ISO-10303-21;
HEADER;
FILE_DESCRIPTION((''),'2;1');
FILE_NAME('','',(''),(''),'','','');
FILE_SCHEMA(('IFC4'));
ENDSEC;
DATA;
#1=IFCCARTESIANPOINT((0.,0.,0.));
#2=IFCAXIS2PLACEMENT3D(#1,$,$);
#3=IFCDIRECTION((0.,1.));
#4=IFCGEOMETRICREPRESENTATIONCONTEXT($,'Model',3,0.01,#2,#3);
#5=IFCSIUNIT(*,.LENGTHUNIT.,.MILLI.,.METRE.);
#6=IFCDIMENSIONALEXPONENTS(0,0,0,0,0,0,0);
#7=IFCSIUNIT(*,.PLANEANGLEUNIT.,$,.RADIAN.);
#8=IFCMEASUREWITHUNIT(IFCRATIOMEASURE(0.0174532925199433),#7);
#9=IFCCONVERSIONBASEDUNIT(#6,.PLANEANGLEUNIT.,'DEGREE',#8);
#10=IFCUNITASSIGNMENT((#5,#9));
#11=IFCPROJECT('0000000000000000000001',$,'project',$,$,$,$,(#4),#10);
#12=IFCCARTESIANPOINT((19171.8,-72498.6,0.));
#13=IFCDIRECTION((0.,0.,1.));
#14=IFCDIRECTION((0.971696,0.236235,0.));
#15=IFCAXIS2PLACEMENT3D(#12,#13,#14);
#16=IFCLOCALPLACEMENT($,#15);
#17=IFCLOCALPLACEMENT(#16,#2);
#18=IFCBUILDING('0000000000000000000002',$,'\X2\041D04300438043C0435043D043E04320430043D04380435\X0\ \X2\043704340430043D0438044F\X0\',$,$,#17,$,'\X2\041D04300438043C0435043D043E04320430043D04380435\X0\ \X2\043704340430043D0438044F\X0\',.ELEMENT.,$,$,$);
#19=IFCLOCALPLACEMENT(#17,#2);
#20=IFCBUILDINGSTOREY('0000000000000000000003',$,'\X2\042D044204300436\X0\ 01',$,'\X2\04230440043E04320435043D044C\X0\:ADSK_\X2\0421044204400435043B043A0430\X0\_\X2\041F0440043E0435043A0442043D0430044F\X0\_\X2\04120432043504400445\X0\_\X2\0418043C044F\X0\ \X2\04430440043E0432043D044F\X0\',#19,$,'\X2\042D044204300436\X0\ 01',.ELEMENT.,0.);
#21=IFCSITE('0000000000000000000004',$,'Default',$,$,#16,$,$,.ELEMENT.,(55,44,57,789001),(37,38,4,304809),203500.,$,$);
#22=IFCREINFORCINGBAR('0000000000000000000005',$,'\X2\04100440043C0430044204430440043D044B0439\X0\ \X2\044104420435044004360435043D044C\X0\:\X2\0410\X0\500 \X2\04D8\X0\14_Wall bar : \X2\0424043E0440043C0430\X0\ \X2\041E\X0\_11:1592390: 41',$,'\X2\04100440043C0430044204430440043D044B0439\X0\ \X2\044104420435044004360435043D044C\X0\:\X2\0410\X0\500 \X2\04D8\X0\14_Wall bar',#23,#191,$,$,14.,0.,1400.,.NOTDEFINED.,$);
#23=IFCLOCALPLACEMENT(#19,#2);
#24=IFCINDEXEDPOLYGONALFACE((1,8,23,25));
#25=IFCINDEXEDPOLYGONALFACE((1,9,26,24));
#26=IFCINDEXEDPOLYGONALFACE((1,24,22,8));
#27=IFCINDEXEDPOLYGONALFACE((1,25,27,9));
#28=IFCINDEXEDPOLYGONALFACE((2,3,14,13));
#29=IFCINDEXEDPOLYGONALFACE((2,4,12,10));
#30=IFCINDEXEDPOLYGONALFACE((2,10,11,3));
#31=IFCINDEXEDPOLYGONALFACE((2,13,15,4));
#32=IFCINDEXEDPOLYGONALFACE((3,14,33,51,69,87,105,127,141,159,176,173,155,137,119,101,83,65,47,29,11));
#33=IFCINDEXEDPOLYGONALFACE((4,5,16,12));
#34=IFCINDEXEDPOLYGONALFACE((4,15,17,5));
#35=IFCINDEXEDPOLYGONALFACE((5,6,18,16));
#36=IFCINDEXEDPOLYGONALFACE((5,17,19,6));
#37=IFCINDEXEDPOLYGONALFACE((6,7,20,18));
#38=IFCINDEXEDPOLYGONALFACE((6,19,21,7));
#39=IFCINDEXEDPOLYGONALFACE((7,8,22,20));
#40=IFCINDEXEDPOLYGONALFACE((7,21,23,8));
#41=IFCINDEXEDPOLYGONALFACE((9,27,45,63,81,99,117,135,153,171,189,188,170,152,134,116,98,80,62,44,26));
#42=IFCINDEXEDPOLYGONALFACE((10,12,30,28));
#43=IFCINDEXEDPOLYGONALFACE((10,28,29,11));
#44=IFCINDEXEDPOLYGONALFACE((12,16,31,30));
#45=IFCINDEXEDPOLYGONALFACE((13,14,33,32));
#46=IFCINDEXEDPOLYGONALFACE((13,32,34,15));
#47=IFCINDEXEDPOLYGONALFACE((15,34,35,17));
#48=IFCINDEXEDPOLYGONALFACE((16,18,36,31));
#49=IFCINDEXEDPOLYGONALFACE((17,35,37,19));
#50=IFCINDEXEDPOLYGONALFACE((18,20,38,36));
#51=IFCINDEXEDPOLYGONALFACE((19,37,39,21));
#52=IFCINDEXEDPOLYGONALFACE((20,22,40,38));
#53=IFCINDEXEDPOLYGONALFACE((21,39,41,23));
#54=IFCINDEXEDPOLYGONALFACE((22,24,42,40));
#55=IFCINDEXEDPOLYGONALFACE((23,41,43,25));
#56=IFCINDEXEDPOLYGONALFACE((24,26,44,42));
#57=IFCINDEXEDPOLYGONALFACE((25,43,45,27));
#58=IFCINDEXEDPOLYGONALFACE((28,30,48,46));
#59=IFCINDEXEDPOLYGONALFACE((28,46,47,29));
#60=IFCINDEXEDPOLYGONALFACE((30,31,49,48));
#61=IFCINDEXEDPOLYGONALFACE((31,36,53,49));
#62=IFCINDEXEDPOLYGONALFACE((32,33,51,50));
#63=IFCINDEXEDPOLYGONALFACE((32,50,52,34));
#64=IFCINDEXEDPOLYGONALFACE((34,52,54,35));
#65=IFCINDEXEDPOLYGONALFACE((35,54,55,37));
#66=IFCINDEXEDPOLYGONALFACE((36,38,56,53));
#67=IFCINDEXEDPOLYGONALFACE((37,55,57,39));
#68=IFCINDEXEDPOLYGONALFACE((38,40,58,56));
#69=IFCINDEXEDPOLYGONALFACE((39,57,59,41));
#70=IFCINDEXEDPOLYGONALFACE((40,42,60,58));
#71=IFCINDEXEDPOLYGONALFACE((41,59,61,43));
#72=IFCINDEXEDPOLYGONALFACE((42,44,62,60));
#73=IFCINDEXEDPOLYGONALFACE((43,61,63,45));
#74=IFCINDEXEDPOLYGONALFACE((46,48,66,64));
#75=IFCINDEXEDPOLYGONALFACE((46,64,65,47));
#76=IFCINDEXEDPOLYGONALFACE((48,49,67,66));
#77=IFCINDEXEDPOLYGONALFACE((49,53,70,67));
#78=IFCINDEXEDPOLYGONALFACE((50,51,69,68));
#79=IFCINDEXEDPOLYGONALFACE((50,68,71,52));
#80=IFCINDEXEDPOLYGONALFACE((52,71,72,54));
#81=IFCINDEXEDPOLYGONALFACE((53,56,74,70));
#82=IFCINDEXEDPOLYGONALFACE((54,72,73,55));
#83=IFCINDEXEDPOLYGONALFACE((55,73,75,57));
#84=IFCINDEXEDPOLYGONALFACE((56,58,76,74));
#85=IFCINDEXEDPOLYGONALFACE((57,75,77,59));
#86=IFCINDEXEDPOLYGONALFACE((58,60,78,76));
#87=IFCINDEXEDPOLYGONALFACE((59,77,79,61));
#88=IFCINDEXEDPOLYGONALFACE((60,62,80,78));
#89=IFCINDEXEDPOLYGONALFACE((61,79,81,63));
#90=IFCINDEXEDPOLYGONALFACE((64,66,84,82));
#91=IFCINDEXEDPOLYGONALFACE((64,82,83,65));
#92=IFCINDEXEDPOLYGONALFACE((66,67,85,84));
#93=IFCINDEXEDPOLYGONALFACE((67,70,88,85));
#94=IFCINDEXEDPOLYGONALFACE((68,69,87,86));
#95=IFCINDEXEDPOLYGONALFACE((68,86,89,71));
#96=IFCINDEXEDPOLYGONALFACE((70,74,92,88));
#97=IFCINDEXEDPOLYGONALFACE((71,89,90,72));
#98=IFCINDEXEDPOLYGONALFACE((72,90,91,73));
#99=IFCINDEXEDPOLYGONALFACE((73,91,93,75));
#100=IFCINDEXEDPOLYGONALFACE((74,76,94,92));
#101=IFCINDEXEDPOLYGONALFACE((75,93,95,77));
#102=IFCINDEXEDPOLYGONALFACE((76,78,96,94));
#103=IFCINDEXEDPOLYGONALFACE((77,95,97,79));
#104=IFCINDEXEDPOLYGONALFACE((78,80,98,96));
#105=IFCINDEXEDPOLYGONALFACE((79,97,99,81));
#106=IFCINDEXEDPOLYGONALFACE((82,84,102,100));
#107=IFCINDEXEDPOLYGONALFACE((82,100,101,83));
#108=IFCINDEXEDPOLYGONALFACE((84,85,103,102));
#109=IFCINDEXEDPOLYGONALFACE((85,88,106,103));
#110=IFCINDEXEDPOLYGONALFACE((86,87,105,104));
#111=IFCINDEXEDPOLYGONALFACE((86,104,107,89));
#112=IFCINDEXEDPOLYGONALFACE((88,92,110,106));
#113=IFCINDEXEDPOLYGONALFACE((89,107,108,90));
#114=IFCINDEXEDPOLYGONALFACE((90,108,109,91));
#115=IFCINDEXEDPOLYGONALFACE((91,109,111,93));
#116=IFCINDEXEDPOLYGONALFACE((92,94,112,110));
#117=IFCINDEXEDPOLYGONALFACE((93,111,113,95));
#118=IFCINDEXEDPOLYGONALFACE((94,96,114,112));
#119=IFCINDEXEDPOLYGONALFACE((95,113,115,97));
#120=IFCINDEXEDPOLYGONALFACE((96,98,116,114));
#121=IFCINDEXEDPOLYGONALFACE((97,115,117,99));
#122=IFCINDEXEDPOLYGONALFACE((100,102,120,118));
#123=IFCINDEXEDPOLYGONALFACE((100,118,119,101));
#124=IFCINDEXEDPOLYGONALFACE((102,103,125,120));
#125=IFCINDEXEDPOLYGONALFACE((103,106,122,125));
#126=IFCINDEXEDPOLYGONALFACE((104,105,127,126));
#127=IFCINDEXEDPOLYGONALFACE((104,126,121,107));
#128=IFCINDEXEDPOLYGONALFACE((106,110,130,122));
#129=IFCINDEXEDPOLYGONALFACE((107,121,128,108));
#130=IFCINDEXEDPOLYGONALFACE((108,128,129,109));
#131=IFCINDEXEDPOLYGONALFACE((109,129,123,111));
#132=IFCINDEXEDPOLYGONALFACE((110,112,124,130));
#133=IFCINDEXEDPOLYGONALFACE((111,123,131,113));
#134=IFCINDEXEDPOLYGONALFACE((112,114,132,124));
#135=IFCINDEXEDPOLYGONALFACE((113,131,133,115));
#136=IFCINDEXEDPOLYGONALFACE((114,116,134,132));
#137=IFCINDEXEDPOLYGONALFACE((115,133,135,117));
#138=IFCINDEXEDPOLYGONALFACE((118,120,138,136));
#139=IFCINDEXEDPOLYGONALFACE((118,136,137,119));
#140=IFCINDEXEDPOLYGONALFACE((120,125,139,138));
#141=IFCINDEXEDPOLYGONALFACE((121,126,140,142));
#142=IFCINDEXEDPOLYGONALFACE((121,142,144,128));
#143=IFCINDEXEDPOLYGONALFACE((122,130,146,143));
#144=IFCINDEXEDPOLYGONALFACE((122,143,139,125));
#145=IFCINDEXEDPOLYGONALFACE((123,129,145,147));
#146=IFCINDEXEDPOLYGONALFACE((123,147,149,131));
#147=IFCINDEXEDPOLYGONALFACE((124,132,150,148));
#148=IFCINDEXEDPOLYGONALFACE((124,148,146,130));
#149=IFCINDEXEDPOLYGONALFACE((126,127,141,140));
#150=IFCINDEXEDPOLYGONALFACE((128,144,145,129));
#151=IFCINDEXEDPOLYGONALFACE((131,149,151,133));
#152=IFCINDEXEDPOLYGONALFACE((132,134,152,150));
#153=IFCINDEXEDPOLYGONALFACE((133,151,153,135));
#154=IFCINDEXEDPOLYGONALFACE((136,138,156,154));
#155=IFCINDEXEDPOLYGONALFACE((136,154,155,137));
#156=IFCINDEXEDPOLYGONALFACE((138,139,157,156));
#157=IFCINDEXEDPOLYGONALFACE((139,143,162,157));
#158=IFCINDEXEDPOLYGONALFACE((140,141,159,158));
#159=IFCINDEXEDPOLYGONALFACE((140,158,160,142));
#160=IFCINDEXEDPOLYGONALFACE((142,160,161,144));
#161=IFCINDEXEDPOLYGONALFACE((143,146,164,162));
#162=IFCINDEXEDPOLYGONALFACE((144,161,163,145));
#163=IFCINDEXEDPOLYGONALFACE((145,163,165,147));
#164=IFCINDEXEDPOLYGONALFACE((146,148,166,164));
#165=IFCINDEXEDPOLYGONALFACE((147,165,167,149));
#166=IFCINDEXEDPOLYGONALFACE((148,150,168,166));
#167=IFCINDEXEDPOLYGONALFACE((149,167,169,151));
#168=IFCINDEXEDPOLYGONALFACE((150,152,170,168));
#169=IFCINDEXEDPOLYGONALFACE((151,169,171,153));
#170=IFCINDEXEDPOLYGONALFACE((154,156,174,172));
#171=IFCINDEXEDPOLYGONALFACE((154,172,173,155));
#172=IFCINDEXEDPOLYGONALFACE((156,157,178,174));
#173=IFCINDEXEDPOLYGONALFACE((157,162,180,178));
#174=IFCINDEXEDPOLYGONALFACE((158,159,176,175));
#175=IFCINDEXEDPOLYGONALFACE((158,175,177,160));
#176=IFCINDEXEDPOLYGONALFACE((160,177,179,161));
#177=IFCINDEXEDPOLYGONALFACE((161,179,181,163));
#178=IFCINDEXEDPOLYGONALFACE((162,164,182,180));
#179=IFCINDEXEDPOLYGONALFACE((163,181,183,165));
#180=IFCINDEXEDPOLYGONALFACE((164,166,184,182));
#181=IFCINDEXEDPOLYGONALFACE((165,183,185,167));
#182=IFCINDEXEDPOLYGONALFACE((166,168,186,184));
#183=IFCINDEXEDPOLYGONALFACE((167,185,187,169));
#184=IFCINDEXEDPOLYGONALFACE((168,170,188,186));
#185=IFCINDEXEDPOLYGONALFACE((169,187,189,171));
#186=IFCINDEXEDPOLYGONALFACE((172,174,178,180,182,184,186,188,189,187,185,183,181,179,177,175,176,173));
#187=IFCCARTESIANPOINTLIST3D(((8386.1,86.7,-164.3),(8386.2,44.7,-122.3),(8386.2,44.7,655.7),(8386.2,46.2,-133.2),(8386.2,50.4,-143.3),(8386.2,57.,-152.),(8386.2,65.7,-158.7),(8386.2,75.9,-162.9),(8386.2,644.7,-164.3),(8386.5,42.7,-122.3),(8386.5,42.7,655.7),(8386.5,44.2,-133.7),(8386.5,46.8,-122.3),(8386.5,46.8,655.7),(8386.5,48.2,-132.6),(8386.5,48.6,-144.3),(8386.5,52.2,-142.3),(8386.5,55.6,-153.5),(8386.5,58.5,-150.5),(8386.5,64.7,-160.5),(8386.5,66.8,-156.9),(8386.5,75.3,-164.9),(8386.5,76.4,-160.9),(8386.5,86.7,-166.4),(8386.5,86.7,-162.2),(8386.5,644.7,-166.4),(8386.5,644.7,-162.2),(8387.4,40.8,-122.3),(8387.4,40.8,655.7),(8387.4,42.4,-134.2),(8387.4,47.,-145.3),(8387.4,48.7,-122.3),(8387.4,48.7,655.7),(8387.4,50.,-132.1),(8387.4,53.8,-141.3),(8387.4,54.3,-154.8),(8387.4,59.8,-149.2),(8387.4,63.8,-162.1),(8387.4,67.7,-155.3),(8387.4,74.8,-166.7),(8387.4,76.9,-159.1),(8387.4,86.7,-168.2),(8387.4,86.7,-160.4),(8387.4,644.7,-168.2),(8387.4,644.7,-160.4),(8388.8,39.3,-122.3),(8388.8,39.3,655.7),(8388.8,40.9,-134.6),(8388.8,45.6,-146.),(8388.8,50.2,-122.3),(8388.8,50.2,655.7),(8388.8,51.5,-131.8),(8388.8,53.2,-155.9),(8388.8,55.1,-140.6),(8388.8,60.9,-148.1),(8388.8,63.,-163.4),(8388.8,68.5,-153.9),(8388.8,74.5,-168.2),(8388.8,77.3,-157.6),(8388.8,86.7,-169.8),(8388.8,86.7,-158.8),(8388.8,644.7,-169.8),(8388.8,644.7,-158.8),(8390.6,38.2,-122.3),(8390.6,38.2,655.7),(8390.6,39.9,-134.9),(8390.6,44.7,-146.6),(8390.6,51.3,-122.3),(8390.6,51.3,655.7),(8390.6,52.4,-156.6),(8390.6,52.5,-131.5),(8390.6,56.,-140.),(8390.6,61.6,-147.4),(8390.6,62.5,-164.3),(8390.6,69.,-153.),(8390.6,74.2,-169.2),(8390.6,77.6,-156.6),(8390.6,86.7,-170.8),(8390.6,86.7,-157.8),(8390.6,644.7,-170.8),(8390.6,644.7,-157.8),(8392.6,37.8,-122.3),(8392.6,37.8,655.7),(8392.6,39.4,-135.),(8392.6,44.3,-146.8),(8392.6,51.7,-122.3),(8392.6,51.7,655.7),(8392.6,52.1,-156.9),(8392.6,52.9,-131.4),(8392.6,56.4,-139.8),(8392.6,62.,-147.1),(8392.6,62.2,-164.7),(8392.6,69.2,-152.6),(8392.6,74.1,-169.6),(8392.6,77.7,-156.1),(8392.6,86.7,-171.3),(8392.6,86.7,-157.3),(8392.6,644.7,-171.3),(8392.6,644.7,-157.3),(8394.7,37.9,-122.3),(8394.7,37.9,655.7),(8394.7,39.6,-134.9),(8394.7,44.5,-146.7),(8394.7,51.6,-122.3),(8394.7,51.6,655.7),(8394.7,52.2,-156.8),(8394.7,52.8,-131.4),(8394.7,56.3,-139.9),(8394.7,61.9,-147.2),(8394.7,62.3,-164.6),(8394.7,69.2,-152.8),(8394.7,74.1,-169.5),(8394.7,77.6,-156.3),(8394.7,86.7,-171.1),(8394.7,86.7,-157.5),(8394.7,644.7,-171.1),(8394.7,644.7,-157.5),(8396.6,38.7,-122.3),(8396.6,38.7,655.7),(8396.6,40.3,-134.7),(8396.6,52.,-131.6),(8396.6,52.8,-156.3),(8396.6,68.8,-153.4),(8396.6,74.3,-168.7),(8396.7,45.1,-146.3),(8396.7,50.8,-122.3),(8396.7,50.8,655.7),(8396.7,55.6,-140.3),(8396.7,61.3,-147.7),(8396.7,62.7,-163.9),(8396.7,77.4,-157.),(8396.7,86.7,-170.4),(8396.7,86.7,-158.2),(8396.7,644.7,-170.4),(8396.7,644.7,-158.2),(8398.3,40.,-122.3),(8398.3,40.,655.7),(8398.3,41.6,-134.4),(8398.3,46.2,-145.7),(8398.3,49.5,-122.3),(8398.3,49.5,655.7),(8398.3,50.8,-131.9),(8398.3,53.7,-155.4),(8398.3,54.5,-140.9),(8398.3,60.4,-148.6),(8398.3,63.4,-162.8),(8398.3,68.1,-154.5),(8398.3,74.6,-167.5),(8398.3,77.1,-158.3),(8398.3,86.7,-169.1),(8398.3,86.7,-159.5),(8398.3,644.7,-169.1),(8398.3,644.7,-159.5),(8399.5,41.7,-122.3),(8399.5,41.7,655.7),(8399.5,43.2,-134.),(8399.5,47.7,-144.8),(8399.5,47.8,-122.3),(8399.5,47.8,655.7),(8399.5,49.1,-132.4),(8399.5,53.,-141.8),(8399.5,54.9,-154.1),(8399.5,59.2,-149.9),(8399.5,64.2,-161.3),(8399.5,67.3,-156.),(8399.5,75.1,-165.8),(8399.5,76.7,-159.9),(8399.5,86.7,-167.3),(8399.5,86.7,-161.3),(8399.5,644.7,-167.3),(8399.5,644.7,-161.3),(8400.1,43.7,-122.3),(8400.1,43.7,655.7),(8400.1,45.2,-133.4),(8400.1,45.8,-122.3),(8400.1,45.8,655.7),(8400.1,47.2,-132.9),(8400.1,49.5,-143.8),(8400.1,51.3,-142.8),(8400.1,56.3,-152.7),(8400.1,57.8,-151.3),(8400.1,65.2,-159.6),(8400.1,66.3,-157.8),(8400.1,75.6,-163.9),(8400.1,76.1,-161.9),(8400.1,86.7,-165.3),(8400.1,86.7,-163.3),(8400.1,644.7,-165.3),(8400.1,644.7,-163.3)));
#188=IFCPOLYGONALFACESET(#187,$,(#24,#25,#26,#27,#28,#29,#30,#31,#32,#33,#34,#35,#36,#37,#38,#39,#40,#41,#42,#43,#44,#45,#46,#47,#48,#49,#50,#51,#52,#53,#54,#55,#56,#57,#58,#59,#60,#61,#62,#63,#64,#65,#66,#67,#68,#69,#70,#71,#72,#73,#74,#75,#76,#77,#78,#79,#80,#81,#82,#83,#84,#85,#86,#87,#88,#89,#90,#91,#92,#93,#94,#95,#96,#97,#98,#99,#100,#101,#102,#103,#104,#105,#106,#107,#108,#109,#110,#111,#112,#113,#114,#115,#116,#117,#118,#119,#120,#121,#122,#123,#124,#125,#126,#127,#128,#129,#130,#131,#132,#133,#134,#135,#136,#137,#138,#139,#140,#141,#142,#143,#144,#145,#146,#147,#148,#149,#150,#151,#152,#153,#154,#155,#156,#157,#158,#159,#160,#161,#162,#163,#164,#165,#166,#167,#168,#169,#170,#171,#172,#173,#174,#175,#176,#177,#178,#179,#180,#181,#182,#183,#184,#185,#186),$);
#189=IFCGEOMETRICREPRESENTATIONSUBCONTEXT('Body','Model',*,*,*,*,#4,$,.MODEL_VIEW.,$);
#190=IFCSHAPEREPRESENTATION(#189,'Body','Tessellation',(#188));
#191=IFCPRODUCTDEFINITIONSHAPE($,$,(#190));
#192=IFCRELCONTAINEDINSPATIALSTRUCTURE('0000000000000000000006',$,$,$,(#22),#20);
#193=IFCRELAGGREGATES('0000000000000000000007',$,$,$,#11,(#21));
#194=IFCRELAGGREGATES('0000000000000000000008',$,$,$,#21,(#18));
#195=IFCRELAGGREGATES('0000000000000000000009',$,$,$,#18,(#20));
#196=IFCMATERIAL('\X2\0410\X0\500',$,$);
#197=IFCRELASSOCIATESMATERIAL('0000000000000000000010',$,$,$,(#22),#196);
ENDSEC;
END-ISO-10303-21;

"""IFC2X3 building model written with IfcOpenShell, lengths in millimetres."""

from ifc_helpers import new_model, entity, si_unit, converted_unit, direction, frame, origin, place, context, subcontext, project, spatial, material, element, save


model = new_model("IFC2X3")

# Units and contexts
model_context = context("Model", 3, precision=0.01, world=origin(), true_north=direction((0.0, 1.0)))
body_context = subcontext(model_context, "Body", "Model", "MODEL_VIEW")
ifc_project = project(units=[si_unit("LENGTHUNIT", "METRE", prefix="MILLI"), converted_unit("PLANEANGLEUNIT", "DEGREE", entity("IfcRatioMeasure", 0.0174532925199433), si_unit("PLANEANGLEUNIT", "RADIAN"), dimensions=[0, 0, 0, 0, 0, 0, 0])], contexts=[model_context])

# Site, building, storey
site_placement = place(None, frame((19171.8, -72498.6, 0.0), z_axis=(0.0, 0.0, 1.0), x_axis=(0.971696, 0.236235, 0.0)))
site = spatial("IfcSite", under=ifc_project, at=site_placement, Name="Default", CompositionType="ELEMENT", RefLatitude=(55, 44, 57, 789001), RefLongitude=(37, 38, 4, 304809), RefElevation=203500.0)
building_placement = place(site_placement, origin())
building = spatial("IfcBuilding", under=site, at=building_placement, Name="Наименование здания", LongName="Наименование здания", CompositionType="ELEMENT")
storey_placement = place(building_placement, origin())
storey = spatial("IfcBuildingStorey", under=building, at=storey_placement, Name="Этаж 01", ObjectType="Уровень:ADSK_Стрелка_Проектная_Вверх_Имя уровня", LongName="Этаж 01", CompositionType="ELEMENT", Elevation=0.0)

# Reinforcing bar
ifc_material = material(Name="А500")
placement = place(storey_placement, origin())
element("IfcReinforcingBar", 1, at=placement, inside=storey, material=ifc_material, Name="Арматурный стержень:А500 Ә14_Wall bar : Форма О_11:1592390: 41", ObjectType="Арматурный стержень:А500 Ә14_Wall bar", BarLength=1400.0, BarRole="NOTDEFINED", CrossSectionArea=0.0, NominalDiameter=14.0, context=body_context, shape_type="AdvancedSweptSolid", body=[
    entity("IfcSweptDiskSolid", entity("IfcCompositeCurve", [entity("IfcCompositeCurveSegment", "CONTINUOUS", True, entity("IfcPolyline", [entity("IfcCartesianPoint", [8393.1, 44.7, 655.7]), entity("IfcCartesianPoint", [8393.1, 44.7, -122.3])])), entity("IfcCompositeCurveSegment", "CONTINUOUS", True, entity("IfcTrimmedCurve", entity("IfcCircle", entity("IfcAxis2Placement3D", entity("IfcCartesianPoint", [8393.1, 86.7, -122.3]), entity("IfcDirection", [1.0, 0.0, 0.0]), entity("IfcDirection", [0.0, 0.0, -1.0])), 42.0), [entity("IfcParameterValue", 270.0)], [entity("IfcParameterValue", 360.0)], True, "PARAMETER")), entity("IfcCompositeCurveSegment", "CONTINUOUS", True, entity("IfcPolyline", [entity("IfcCartesianPoint", [8393.1, 86.7, -164.3]), entity("IfcCartesianPoint", [8393.1, 644.7, -164.3])]))], False), 7.0, None, 0.0, 92.0),
])

save(model, "model.ifc")
